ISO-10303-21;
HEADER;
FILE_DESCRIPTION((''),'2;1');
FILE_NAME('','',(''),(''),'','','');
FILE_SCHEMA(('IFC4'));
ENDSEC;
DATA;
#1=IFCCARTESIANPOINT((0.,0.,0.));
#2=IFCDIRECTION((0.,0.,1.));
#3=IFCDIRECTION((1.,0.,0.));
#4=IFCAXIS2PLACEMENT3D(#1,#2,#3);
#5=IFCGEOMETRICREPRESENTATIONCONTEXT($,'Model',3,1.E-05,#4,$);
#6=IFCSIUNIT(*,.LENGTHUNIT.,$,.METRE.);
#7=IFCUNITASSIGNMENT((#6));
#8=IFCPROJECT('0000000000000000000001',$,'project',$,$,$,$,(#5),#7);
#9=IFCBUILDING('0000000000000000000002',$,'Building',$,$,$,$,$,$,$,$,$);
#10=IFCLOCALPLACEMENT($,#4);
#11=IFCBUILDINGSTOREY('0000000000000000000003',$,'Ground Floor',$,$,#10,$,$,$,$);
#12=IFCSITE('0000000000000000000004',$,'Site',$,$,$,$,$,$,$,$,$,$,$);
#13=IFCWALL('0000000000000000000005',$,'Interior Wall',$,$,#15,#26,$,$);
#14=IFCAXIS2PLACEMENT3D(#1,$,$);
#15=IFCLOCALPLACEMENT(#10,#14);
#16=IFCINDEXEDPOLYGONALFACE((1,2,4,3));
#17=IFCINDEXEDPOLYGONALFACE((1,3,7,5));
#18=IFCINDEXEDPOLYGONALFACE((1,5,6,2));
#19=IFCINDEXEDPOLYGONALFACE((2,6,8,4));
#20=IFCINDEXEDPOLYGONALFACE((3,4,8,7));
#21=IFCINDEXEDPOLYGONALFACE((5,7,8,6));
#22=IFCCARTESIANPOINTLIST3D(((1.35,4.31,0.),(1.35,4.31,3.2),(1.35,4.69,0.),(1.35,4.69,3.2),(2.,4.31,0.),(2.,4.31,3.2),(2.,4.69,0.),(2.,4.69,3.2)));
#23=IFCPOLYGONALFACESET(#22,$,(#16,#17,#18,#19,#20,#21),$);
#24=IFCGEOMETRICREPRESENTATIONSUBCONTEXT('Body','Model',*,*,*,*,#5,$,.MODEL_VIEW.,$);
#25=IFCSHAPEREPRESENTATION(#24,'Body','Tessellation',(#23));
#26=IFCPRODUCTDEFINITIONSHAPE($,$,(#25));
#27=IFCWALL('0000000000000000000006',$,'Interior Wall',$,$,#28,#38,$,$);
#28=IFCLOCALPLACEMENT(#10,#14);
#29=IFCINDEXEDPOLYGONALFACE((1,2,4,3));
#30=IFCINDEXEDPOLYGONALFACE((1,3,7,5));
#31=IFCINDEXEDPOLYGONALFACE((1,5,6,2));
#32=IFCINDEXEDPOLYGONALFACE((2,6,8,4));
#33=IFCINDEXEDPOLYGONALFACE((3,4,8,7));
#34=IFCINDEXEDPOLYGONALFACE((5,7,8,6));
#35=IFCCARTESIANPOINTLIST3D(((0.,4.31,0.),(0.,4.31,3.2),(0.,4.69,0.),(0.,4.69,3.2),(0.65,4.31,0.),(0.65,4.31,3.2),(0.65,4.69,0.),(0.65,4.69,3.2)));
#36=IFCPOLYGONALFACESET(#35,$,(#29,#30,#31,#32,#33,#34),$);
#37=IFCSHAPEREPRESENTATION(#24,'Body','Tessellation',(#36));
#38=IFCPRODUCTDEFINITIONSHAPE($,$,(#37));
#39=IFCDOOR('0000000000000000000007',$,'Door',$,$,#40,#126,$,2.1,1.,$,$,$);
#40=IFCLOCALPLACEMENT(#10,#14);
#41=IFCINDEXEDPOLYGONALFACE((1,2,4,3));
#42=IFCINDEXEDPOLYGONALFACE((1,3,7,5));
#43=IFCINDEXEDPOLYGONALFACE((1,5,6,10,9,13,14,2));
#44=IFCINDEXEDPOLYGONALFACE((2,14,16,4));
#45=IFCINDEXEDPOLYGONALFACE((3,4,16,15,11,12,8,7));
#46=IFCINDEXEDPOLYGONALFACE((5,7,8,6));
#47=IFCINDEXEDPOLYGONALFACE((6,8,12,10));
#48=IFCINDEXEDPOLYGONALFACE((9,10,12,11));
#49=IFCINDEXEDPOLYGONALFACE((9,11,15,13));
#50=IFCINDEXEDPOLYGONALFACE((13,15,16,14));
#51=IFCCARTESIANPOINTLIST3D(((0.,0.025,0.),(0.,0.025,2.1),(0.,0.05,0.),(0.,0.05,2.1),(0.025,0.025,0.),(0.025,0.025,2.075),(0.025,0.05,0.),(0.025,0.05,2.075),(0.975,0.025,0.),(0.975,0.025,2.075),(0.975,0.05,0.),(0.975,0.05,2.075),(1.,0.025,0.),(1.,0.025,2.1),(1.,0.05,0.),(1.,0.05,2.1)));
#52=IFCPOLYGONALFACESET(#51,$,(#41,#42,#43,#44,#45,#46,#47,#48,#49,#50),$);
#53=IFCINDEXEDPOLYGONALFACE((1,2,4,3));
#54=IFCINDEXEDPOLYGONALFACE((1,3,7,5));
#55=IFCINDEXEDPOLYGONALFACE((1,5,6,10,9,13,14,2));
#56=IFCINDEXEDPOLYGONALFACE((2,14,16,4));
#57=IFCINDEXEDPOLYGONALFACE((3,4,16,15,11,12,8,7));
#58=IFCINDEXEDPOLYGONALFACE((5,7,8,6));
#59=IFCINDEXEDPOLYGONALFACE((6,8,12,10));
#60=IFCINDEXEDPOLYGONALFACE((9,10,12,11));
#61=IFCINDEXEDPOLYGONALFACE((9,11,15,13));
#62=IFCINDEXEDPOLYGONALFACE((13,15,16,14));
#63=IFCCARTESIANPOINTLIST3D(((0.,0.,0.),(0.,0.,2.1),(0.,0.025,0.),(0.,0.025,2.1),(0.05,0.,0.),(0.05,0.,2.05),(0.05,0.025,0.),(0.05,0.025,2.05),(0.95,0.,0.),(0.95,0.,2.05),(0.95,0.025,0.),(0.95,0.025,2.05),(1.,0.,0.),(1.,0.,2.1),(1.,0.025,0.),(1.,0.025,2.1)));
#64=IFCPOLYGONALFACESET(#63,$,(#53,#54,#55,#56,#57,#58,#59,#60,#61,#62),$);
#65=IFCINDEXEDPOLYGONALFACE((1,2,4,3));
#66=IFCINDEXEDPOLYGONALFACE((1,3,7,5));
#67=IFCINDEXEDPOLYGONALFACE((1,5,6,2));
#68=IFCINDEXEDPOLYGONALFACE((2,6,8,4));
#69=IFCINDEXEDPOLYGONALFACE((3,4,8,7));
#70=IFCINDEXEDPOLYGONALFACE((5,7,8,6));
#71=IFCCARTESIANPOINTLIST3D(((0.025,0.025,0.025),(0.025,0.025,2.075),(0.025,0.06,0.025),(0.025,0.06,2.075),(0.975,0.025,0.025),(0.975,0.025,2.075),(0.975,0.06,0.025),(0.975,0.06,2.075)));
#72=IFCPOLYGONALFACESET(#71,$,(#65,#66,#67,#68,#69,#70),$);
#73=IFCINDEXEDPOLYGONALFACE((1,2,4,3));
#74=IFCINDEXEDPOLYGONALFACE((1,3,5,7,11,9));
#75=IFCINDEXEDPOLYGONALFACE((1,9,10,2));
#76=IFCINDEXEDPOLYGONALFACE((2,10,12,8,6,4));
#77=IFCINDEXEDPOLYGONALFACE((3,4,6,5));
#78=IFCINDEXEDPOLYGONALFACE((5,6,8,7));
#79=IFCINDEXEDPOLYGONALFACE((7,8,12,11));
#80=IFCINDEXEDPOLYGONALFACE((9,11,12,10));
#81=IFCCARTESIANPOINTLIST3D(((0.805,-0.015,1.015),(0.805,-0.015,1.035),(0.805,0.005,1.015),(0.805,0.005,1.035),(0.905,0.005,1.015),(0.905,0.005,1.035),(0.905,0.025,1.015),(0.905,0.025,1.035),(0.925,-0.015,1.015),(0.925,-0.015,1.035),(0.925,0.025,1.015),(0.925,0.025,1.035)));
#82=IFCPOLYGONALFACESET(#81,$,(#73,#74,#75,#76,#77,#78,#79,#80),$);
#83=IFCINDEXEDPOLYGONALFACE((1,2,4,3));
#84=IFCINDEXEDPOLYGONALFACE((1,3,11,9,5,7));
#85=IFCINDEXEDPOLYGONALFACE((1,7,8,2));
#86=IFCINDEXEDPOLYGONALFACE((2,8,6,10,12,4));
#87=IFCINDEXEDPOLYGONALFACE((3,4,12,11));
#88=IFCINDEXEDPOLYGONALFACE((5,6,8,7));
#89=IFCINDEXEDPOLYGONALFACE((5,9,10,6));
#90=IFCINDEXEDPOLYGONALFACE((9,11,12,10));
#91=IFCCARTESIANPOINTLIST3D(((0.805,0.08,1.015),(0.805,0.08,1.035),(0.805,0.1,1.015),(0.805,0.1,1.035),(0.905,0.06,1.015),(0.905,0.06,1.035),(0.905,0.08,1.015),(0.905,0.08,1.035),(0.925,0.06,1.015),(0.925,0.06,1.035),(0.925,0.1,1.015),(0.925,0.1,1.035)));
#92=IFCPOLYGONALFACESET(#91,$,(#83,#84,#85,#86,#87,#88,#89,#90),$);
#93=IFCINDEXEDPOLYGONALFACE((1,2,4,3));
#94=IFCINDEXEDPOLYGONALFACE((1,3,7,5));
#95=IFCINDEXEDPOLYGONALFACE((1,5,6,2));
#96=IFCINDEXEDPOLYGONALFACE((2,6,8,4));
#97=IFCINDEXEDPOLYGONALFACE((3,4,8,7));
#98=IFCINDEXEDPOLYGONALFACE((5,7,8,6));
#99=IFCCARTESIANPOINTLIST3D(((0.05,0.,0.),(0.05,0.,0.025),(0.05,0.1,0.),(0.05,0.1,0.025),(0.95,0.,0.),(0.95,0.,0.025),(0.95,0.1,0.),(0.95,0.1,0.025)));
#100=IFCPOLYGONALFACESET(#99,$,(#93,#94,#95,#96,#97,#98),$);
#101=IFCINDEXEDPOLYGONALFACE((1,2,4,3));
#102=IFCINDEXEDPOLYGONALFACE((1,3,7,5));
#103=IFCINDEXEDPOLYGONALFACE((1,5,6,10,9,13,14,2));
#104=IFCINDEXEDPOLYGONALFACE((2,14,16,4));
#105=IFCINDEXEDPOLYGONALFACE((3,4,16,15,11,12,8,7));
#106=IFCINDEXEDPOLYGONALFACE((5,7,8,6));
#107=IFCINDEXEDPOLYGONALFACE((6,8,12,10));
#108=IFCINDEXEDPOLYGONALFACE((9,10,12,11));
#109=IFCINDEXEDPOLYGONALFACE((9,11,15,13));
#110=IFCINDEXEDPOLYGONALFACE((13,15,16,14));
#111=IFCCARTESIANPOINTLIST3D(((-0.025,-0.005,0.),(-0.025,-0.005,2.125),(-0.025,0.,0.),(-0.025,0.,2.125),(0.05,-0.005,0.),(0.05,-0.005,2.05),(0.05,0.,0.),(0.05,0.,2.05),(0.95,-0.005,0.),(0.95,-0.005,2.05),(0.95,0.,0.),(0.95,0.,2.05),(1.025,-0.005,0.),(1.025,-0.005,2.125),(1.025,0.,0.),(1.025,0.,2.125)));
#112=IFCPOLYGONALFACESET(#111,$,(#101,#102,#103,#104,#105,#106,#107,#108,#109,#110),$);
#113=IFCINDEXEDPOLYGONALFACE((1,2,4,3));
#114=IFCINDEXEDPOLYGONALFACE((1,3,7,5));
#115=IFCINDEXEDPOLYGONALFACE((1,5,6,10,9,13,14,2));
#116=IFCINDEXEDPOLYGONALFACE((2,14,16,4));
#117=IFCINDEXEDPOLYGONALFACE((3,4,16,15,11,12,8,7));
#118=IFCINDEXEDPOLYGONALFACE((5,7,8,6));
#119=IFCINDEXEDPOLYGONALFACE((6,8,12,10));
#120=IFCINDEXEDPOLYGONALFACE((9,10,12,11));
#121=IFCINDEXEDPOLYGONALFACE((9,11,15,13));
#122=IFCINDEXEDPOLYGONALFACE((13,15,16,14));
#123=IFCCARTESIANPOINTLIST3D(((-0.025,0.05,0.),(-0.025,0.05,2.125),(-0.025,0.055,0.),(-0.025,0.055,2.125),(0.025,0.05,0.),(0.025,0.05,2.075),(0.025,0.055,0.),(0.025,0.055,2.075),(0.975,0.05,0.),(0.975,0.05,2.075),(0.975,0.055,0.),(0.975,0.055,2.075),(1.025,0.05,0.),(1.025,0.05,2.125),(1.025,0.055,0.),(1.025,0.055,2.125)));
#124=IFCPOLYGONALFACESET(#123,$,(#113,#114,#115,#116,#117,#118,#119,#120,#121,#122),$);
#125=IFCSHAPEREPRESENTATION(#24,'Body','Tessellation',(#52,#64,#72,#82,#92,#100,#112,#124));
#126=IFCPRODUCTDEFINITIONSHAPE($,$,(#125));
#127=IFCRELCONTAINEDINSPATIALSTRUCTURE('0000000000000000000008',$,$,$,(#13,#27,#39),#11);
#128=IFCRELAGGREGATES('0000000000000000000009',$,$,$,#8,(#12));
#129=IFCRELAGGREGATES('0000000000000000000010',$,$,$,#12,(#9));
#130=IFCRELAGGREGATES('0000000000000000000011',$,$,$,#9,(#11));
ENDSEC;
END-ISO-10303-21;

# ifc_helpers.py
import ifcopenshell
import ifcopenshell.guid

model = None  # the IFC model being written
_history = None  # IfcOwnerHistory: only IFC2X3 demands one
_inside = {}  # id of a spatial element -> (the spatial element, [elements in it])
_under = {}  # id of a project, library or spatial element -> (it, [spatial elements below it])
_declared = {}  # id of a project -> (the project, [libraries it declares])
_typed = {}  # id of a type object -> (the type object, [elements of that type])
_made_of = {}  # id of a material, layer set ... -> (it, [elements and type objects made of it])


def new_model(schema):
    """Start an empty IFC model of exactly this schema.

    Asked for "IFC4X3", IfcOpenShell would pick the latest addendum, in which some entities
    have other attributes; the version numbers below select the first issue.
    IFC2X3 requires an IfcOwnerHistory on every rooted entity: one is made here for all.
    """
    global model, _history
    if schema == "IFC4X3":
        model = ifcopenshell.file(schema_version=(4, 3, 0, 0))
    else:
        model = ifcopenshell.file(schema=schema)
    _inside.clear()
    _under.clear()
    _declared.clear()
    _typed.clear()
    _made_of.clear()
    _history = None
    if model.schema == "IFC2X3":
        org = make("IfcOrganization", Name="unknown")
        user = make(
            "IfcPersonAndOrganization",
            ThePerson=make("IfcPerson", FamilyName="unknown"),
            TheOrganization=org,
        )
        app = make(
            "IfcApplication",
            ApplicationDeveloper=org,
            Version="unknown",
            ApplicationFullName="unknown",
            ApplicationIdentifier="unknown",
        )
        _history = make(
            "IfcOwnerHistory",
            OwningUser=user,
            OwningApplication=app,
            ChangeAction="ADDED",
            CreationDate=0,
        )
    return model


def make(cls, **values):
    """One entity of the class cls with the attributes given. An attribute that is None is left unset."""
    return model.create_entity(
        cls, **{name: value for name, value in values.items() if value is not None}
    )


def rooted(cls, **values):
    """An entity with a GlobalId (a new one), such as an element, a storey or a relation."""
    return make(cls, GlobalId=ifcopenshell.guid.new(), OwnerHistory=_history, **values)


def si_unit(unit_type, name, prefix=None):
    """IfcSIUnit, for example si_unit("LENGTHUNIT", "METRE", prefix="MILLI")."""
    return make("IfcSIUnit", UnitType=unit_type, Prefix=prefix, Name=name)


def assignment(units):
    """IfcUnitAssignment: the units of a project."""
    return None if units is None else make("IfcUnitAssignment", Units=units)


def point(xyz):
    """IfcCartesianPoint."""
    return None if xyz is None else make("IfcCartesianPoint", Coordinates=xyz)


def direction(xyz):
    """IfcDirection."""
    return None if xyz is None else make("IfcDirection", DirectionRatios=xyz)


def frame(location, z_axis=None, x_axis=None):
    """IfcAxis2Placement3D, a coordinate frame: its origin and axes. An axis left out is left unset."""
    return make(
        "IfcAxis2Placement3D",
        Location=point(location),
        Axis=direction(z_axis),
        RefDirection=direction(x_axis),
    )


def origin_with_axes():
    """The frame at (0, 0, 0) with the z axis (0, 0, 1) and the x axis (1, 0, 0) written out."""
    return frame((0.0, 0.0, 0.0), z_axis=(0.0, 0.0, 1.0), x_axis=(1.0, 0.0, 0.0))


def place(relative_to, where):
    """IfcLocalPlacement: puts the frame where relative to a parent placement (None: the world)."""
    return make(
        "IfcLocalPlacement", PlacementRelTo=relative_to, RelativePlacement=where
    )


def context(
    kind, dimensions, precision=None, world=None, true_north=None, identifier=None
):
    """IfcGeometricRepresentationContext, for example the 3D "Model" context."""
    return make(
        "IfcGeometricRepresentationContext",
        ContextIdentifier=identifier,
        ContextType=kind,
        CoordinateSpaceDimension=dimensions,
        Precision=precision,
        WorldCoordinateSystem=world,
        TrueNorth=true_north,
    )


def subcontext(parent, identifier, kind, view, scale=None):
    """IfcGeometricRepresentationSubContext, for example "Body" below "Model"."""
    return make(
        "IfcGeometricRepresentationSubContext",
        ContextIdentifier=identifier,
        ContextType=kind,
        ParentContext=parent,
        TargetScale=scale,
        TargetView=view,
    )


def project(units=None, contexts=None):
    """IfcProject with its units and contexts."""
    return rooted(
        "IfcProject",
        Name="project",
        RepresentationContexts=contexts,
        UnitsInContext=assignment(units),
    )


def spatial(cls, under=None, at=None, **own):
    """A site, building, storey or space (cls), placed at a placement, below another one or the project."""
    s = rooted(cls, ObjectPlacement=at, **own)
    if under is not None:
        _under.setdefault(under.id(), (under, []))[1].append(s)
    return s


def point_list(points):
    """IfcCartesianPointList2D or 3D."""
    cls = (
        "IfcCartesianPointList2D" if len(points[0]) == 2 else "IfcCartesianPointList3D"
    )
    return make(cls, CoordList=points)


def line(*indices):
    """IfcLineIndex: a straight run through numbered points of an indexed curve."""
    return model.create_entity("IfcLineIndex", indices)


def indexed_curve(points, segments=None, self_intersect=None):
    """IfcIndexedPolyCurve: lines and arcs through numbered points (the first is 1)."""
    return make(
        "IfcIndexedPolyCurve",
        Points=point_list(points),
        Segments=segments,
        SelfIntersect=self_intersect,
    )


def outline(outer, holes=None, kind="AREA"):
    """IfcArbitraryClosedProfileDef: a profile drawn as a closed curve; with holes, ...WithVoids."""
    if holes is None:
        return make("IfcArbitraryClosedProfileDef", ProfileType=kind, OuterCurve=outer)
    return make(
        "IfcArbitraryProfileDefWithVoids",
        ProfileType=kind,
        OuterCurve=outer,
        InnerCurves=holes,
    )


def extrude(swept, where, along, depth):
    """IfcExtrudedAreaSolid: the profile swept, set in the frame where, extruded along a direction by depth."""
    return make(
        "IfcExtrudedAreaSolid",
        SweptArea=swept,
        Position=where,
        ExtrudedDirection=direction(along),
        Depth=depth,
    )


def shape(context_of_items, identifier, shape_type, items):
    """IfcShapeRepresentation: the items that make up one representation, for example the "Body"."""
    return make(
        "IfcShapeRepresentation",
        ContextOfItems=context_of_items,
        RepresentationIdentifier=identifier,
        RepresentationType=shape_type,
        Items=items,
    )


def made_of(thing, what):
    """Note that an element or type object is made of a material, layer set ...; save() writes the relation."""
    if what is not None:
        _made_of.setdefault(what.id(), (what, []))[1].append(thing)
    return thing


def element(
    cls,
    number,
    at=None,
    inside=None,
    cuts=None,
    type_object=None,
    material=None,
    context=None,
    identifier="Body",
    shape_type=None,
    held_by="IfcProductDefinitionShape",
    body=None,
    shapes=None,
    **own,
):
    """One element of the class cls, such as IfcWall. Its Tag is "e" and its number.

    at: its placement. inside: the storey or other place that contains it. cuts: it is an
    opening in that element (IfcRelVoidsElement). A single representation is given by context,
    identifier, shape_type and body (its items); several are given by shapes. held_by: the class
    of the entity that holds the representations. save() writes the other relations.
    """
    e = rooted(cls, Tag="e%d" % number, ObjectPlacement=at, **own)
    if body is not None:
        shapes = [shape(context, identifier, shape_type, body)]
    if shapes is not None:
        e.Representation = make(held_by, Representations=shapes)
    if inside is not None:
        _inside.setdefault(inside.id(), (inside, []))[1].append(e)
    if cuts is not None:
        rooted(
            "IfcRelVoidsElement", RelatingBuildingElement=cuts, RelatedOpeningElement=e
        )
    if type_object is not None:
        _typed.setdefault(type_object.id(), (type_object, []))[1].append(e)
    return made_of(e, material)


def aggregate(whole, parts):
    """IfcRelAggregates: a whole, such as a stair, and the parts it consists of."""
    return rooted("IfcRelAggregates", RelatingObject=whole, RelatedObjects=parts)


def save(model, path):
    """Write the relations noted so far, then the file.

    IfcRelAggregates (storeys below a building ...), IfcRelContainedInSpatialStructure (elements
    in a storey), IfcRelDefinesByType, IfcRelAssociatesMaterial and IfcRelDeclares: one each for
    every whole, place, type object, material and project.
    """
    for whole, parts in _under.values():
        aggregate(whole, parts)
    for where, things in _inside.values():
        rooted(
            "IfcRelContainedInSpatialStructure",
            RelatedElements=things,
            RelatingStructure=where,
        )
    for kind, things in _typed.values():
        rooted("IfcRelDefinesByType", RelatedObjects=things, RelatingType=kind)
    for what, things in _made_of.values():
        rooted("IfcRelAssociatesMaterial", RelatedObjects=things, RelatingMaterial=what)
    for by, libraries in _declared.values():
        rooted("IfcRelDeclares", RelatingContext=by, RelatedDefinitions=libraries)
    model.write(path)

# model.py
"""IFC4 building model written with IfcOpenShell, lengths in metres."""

from ifc_helpers import new_model, si_unit, frame, origin_with_axes, place, context, subcontext, project, spatial, line, indexed_curve, outline, extrude, element, save


model = new_model("IFC4")

# Units and contexts
model_context = context("Model", 3, precision=1e-05, world=origin_with_axes())
body_context = subcontext(model_context, "Body", "Model", "MODEL_VIEW")
ifc_project = project(units=[si_unit("LENGTHUNIT", "METRE")], contexts=[model_context])

# Site, building, storey
site = spatial("IfcSite", under=ifc_project, Name="Site")
building = spatial("IfcBuilding", under=site, Name="Building")
storey_placement = place(None, origin_with_axes())
storey = spatial("IfcBuildingStorey", under=building, at=storey_placement, Name="Ground Floor")

# Walls
for number, where, z_axis, x_axis, name in (
    (1, (2.0, 4.5, 0.0), (0.0, 0.0, 1.0), (-1.0, 0.0, 0.0), "Interior Wall"),
    (2, (0.65, 4.5, 0.0), (0.0, 0.0, 1.0), (-1.0, 0.0, 0.0), "Interior Wall"),
):
    element("IfcWall", number, at=place(storey_placement, frame(where, z_axis=z_axis, x_axis=x_axis)), inside=storey, Name=name, context=body_context, shape_type="SweptSolid", body=[
        extrude(outline(indexed_curve([(0.0, 0.0), (0.0, 0.38), (0.65, 0.38), (0.65, 0.0), (0.0, 0.0)], self_intersect=False)), frame((0.0, -0.19, 0.0), z_axis=(0.0, 0.0, 1.0), x_axis=(1.0, 0.0, 0.0)), (0.0, 0.0, 1.0), 3.2),
    ])

# Door
door_1_placement = place(storey_placement, origin_with_axes())
element("IfcDoor", 3, at=door_1_placement, inside=storey, Name="Door", OverallHeight=2.1, OverallWidth=1.0, context=body_context, shape_type="SweptSolid", body=[
    extrude(outline(indexed_curve([(0.0, 0.0), (0.0, 2.1), (1.0, 2.1), (1.0, 0.0), (0.975, 0.0), (0.975, 2.075), (0.025, 2.075), (0.025, 0.0)], segments=[line(1, 2, 3, 4, 5, 6, 7, 8, 1)])), frame((0.0, 0.025, 0.0), z_axis=(0.0, -1.0, 0.0), x_axis=(1.0, 0.0, 0.0)), (0.0, 0.0, -1.0), 0.025),
    extrude(outline(indexed_curve([(0.0, 0.0), (0.0, 2.1), (1.0, 2.1), (1.0, 0.0), (0.95, 0.0), (0.95, 2.05), (0.05, 2.05), (0.05, 0.0)], segments=[line(1, 2, 3, 4, 5, 6, 7, 8, 1)])), frame((0.0, 0.0, 0.0), z_axis=(0.0, -1.0, 0.0), x_axis=(1.0, 0.0, 0.0)), (0.0, 0.0, -1.0), 0.025),
    extrude(outline(indexed_curve([(0.0, 0.0), (0.95, 0.0), (0.95, 0.035), (0.0, 0.035)], segments=[line(1, 2, 3, 4, 1)])), frame((0.025, 0.025, 0.025), z_axis=(0.0, 0.0, 1.0), x_axis=(1.0, 0.0, 0.0)), (0.0, 0.0, 1.0), 2.05),
    extrude(outline(indexed_curve([(0.0, 0.0), (0.0, -0.04), (-0.12, -0.04), (-0.12, -0.02), (-0.02, -0.02), (-0.02, 0.0)], segments=[line(1, 2, 3, 4, 5, 6, 1)])), frame((0.925, 0.025, 1.015), z_axis=(0.0, 0.0, 1.0), x_axis=(1.0, 0.0, 0.0)), (0.0, 0.0, 1.0), 0.02),
    extrude(outline(indexed_curve([(0.0, 0.0), (0.0, 0.04), (-0.12, 0.04), (-0.12, 0.02), (-0.02, 0.02), (-0.02, 0.0)], segments=[line(1, 2, 3, 4, 5, 6, 1)])), frame((0.925, 0.06, 1.015), z_axis=(0.0, 0.0, 1.0), x_axis=(1.0, 0.0, 0.0)), (0.0, 0.0, 1.0), 0.02),
    extrude(outline(indexed_curve([(0.0, 0.0), (0.9, 0.0), (0.9, 0.1), (0.0, 0.1)], segments=[line(1, 2, 3, 4, 1)])), frame((0.05, 0.0, 0.0), z_axis=(0.0, 0.0, 1.0), x_axis=(1.0, 0.0, 0.0)), (0.0, 0.0, 1.0), 0.025),
    extrude(outline(indexed_curve([(0.0, 0.0), (0.0, 2.125), (1.05, 2.125), (1.05, 0.0), (0.975, 0.0), (0.975, 2.05), (0.075, 2.05), (0.075, 0.0)], segments=[line(1, 2, 3, 4, 5, 6, 7, 8, 1)])), frame((-0.025, -0.005, 0.0), z_axis=(0.0, -1.0, 0.0), x_axis=(1.0, 0.0, 0.0)), (0.0, 0.0, -1.0), 0.005),
    extrude(outline(indexed_curve([(0.0, 0.0), (0.0, 2.125), (1.05, 2.125), (1.05, 0.0), (1.0, 0.0), (1.0, 2.075), (0.05, 2.075), (0.05, 0.0)], segments=[line(1, 2, 3, 4, 5, 6, 7, 8, 1)])), frame((-0.025, 0.05, 0.0), z_axis=(0.0, -1.0, 0.0), x_axis=(1.0, 0.0, 0.0)), (0.0, 0.0, -1.0), 0.005),
])

save(model, "model.ifc")
